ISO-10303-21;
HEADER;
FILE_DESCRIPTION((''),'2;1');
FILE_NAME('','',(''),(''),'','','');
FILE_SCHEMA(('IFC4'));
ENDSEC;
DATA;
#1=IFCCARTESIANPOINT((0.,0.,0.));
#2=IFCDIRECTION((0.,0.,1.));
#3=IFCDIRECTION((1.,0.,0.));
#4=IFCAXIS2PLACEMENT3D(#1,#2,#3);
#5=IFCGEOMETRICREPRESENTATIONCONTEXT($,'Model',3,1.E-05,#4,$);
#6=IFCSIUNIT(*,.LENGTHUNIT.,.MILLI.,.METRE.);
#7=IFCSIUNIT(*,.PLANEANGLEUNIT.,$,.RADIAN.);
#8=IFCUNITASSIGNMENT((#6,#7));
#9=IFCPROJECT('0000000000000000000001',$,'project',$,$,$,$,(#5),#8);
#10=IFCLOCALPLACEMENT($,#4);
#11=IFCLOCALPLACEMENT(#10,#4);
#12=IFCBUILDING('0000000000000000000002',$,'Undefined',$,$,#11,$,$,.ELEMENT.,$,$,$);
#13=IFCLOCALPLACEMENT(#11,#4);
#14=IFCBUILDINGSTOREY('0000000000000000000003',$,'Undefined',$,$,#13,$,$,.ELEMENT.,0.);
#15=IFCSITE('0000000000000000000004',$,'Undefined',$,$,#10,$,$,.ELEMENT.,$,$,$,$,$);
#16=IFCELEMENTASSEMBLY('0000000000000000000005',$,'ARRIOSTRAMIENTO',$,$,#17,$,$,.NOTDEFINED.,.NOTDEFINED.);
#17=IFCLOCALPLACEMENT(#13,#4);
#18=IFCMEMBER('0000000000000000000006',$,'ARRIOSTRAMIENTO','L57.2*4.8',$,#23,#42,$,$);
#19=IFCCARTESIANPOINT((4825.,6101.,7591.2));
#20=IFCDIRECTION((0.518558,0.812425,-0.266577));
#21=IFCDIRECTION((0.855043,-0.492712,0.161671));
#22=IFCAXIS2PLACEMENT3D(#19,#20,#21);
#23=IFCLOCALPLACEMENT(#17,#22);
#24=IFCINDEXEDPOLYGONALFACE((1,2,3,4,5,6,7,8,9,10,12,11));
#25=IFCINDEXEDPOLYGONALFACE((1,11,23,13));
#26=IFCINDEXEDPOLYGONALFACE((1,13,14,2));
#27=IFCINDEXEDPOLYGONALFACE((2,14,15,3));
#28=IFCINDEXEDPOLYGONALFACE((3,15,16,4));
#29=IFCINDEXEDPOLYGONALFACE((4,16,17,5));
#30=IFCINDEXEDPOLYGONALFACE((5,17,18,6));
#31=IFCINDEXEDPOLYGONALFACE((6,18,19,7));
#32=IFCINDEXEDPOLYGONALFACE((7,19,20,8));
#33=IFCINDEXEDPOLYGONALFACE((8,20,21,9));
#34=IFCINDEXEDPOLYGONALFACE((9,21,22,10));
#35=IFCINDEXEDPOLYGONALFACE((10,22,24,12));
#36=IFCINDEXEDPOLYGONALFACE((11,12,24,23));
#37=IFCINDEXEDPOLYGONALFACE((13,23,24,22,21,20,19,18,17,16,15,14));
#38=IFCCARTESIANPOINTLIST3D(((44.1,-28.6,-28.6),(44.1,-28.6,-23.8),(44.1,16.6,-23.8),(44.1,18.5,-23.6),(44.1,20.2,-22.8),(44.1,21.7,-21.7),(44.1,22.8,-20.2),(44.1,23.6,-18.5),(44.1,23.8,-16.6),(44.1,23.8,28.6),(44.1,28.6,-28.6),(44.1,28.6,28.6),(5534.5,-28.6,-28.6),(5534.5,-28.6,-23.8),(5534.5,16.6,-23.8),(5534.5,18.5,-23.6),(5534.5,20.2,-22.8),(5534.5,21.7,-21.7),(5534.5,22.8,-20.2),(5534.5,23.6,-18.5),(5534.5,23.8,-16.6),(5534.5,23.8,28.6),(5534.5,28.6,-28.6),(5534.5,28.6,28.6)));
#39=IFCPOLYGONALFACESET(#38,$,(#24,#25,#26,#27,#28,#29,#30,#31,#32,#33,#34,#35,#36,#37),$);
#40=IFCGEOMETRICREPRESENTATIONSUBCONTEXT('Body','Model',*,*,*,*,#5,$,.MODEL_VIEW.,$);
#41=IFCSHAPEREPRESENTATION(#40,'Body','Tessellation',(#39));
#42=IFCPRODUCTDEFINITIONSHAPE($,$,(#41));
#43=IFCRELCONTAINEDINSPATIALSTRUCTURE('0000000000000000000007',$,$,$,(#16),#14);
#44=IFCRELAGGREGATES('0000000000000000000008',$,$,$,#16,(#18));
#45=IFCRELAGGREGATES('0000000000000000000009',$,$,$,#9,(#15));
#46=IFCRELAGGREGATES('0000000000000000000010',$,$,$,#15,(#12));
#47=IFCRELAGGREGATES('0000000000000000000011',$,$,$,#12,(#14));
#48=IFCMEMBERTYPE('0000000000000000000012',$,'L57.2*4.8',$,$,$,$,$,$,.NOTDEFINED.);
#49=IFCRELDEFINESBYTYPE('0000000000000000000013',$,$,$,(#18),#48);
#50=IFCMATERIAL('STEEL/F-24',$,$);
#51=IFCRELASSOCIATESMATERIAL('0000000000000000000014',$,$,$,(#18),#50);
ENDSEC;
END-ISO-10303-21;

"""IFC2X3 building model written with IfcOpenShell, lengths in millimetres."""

from ifc_helpers import new_model, si_unit, frame, origin_with_axes, origin_2d_with_axis, place, context, subcontext, project, spatial, l_section, extrude, clip, halfspace, material, type_object, element, aggregate, save


model = new_model("IFC2X3")

# Units and contexts
model_context = context("Model", 3, precision=1e-05, world=origin_with_axes())
body_context = subcontext(model_context, "Body", "Model", "MODEL_VIEW")
ifc_project = project(units=[si_unit("LENGTHUNIT", "METRE", prefix="MILLI"), si_unit("PLANEANGLEUNIT", "RADIAN")], contexts=[model_context])

# Site, building, storey
site_placement = place(None, origin_with_axes())
site = spatial("IfcSite", under=ifc_project, at=site_placement, Name="Undefined", CompositionType="ELEMENT")
building_placement = place(site_placement, origin_with_axes())
building = spatial("IfcBuilding", under=site, at=building_placement, Name="Undefined", CompositionType="ELEMENT")
storey_placement = place(building_placement, origin_with_axes())
storey = spatial("IfcBuildingStorey", under=building, at=storey_placement, Name="Undefined", CompositionType="ELEMENT", Elevation=0.0)

# Shared definitions
ifc_material_1 = material(Name="STEEL/F-24")

# Element assembly, member
member_type = type_object("IfcMemberType", Name="L57.2*4.8", PredefinedType="NOTDEFINED")
assembly_1_placement = place(storey_placement, origin_with_axes())
assembly_1 = element("IfcElementAssembly", 1, at=assembly_1_placement, inside=storey, Name="ARRIOSTRAMIENTO", AssemblyPlace="NOTDEFINED", PredefinedType="NOTDEFINED")
member_1_placement = place(assembly_1_placement, frame((4825.0, 6101.0, 7591.2), z_axis=(0.518558, 0.812425, -0.266577), x_axis=(0.855043, -0.492712, 0.161671)))
member_1 = element("IfcMember", 2, at=member_1_placement, type_object=member_type, material=ifc_material_1, Name="ARRIOSTRAMIENTO", Description="L57.2*4.8", context=body_context, shape_type="Clipping", body=[
    clip(clip(extrude(l_section(Depth=57.2, Width=57.2, Thickness=4.8, FilletRadius=7.2, at=origin_2d_with_axis()), frame((5595.4, 0.0, 0.0), z_axis=(-1.0, 0.0, 0.0), x_axis=(0.0, -1.0, 0.0)), (0.0, 0.0, 1.0), 5612.1), halfspace(frame((5534.5, 28.6, 0.0), z_axis=(-1.0, 0.0, 0.0), x_axis=(0.0, 0.000039, 1.0)), True)), halfspace(frame((44.1, 38.1, 0.0), z_axis=(1.0, 0.0, 0.0), x_axis=(0.0, -0.000039, -1.0)), True)),
])

aggregate(assembly_1, [member_1])

save(model, "model.ifc")
